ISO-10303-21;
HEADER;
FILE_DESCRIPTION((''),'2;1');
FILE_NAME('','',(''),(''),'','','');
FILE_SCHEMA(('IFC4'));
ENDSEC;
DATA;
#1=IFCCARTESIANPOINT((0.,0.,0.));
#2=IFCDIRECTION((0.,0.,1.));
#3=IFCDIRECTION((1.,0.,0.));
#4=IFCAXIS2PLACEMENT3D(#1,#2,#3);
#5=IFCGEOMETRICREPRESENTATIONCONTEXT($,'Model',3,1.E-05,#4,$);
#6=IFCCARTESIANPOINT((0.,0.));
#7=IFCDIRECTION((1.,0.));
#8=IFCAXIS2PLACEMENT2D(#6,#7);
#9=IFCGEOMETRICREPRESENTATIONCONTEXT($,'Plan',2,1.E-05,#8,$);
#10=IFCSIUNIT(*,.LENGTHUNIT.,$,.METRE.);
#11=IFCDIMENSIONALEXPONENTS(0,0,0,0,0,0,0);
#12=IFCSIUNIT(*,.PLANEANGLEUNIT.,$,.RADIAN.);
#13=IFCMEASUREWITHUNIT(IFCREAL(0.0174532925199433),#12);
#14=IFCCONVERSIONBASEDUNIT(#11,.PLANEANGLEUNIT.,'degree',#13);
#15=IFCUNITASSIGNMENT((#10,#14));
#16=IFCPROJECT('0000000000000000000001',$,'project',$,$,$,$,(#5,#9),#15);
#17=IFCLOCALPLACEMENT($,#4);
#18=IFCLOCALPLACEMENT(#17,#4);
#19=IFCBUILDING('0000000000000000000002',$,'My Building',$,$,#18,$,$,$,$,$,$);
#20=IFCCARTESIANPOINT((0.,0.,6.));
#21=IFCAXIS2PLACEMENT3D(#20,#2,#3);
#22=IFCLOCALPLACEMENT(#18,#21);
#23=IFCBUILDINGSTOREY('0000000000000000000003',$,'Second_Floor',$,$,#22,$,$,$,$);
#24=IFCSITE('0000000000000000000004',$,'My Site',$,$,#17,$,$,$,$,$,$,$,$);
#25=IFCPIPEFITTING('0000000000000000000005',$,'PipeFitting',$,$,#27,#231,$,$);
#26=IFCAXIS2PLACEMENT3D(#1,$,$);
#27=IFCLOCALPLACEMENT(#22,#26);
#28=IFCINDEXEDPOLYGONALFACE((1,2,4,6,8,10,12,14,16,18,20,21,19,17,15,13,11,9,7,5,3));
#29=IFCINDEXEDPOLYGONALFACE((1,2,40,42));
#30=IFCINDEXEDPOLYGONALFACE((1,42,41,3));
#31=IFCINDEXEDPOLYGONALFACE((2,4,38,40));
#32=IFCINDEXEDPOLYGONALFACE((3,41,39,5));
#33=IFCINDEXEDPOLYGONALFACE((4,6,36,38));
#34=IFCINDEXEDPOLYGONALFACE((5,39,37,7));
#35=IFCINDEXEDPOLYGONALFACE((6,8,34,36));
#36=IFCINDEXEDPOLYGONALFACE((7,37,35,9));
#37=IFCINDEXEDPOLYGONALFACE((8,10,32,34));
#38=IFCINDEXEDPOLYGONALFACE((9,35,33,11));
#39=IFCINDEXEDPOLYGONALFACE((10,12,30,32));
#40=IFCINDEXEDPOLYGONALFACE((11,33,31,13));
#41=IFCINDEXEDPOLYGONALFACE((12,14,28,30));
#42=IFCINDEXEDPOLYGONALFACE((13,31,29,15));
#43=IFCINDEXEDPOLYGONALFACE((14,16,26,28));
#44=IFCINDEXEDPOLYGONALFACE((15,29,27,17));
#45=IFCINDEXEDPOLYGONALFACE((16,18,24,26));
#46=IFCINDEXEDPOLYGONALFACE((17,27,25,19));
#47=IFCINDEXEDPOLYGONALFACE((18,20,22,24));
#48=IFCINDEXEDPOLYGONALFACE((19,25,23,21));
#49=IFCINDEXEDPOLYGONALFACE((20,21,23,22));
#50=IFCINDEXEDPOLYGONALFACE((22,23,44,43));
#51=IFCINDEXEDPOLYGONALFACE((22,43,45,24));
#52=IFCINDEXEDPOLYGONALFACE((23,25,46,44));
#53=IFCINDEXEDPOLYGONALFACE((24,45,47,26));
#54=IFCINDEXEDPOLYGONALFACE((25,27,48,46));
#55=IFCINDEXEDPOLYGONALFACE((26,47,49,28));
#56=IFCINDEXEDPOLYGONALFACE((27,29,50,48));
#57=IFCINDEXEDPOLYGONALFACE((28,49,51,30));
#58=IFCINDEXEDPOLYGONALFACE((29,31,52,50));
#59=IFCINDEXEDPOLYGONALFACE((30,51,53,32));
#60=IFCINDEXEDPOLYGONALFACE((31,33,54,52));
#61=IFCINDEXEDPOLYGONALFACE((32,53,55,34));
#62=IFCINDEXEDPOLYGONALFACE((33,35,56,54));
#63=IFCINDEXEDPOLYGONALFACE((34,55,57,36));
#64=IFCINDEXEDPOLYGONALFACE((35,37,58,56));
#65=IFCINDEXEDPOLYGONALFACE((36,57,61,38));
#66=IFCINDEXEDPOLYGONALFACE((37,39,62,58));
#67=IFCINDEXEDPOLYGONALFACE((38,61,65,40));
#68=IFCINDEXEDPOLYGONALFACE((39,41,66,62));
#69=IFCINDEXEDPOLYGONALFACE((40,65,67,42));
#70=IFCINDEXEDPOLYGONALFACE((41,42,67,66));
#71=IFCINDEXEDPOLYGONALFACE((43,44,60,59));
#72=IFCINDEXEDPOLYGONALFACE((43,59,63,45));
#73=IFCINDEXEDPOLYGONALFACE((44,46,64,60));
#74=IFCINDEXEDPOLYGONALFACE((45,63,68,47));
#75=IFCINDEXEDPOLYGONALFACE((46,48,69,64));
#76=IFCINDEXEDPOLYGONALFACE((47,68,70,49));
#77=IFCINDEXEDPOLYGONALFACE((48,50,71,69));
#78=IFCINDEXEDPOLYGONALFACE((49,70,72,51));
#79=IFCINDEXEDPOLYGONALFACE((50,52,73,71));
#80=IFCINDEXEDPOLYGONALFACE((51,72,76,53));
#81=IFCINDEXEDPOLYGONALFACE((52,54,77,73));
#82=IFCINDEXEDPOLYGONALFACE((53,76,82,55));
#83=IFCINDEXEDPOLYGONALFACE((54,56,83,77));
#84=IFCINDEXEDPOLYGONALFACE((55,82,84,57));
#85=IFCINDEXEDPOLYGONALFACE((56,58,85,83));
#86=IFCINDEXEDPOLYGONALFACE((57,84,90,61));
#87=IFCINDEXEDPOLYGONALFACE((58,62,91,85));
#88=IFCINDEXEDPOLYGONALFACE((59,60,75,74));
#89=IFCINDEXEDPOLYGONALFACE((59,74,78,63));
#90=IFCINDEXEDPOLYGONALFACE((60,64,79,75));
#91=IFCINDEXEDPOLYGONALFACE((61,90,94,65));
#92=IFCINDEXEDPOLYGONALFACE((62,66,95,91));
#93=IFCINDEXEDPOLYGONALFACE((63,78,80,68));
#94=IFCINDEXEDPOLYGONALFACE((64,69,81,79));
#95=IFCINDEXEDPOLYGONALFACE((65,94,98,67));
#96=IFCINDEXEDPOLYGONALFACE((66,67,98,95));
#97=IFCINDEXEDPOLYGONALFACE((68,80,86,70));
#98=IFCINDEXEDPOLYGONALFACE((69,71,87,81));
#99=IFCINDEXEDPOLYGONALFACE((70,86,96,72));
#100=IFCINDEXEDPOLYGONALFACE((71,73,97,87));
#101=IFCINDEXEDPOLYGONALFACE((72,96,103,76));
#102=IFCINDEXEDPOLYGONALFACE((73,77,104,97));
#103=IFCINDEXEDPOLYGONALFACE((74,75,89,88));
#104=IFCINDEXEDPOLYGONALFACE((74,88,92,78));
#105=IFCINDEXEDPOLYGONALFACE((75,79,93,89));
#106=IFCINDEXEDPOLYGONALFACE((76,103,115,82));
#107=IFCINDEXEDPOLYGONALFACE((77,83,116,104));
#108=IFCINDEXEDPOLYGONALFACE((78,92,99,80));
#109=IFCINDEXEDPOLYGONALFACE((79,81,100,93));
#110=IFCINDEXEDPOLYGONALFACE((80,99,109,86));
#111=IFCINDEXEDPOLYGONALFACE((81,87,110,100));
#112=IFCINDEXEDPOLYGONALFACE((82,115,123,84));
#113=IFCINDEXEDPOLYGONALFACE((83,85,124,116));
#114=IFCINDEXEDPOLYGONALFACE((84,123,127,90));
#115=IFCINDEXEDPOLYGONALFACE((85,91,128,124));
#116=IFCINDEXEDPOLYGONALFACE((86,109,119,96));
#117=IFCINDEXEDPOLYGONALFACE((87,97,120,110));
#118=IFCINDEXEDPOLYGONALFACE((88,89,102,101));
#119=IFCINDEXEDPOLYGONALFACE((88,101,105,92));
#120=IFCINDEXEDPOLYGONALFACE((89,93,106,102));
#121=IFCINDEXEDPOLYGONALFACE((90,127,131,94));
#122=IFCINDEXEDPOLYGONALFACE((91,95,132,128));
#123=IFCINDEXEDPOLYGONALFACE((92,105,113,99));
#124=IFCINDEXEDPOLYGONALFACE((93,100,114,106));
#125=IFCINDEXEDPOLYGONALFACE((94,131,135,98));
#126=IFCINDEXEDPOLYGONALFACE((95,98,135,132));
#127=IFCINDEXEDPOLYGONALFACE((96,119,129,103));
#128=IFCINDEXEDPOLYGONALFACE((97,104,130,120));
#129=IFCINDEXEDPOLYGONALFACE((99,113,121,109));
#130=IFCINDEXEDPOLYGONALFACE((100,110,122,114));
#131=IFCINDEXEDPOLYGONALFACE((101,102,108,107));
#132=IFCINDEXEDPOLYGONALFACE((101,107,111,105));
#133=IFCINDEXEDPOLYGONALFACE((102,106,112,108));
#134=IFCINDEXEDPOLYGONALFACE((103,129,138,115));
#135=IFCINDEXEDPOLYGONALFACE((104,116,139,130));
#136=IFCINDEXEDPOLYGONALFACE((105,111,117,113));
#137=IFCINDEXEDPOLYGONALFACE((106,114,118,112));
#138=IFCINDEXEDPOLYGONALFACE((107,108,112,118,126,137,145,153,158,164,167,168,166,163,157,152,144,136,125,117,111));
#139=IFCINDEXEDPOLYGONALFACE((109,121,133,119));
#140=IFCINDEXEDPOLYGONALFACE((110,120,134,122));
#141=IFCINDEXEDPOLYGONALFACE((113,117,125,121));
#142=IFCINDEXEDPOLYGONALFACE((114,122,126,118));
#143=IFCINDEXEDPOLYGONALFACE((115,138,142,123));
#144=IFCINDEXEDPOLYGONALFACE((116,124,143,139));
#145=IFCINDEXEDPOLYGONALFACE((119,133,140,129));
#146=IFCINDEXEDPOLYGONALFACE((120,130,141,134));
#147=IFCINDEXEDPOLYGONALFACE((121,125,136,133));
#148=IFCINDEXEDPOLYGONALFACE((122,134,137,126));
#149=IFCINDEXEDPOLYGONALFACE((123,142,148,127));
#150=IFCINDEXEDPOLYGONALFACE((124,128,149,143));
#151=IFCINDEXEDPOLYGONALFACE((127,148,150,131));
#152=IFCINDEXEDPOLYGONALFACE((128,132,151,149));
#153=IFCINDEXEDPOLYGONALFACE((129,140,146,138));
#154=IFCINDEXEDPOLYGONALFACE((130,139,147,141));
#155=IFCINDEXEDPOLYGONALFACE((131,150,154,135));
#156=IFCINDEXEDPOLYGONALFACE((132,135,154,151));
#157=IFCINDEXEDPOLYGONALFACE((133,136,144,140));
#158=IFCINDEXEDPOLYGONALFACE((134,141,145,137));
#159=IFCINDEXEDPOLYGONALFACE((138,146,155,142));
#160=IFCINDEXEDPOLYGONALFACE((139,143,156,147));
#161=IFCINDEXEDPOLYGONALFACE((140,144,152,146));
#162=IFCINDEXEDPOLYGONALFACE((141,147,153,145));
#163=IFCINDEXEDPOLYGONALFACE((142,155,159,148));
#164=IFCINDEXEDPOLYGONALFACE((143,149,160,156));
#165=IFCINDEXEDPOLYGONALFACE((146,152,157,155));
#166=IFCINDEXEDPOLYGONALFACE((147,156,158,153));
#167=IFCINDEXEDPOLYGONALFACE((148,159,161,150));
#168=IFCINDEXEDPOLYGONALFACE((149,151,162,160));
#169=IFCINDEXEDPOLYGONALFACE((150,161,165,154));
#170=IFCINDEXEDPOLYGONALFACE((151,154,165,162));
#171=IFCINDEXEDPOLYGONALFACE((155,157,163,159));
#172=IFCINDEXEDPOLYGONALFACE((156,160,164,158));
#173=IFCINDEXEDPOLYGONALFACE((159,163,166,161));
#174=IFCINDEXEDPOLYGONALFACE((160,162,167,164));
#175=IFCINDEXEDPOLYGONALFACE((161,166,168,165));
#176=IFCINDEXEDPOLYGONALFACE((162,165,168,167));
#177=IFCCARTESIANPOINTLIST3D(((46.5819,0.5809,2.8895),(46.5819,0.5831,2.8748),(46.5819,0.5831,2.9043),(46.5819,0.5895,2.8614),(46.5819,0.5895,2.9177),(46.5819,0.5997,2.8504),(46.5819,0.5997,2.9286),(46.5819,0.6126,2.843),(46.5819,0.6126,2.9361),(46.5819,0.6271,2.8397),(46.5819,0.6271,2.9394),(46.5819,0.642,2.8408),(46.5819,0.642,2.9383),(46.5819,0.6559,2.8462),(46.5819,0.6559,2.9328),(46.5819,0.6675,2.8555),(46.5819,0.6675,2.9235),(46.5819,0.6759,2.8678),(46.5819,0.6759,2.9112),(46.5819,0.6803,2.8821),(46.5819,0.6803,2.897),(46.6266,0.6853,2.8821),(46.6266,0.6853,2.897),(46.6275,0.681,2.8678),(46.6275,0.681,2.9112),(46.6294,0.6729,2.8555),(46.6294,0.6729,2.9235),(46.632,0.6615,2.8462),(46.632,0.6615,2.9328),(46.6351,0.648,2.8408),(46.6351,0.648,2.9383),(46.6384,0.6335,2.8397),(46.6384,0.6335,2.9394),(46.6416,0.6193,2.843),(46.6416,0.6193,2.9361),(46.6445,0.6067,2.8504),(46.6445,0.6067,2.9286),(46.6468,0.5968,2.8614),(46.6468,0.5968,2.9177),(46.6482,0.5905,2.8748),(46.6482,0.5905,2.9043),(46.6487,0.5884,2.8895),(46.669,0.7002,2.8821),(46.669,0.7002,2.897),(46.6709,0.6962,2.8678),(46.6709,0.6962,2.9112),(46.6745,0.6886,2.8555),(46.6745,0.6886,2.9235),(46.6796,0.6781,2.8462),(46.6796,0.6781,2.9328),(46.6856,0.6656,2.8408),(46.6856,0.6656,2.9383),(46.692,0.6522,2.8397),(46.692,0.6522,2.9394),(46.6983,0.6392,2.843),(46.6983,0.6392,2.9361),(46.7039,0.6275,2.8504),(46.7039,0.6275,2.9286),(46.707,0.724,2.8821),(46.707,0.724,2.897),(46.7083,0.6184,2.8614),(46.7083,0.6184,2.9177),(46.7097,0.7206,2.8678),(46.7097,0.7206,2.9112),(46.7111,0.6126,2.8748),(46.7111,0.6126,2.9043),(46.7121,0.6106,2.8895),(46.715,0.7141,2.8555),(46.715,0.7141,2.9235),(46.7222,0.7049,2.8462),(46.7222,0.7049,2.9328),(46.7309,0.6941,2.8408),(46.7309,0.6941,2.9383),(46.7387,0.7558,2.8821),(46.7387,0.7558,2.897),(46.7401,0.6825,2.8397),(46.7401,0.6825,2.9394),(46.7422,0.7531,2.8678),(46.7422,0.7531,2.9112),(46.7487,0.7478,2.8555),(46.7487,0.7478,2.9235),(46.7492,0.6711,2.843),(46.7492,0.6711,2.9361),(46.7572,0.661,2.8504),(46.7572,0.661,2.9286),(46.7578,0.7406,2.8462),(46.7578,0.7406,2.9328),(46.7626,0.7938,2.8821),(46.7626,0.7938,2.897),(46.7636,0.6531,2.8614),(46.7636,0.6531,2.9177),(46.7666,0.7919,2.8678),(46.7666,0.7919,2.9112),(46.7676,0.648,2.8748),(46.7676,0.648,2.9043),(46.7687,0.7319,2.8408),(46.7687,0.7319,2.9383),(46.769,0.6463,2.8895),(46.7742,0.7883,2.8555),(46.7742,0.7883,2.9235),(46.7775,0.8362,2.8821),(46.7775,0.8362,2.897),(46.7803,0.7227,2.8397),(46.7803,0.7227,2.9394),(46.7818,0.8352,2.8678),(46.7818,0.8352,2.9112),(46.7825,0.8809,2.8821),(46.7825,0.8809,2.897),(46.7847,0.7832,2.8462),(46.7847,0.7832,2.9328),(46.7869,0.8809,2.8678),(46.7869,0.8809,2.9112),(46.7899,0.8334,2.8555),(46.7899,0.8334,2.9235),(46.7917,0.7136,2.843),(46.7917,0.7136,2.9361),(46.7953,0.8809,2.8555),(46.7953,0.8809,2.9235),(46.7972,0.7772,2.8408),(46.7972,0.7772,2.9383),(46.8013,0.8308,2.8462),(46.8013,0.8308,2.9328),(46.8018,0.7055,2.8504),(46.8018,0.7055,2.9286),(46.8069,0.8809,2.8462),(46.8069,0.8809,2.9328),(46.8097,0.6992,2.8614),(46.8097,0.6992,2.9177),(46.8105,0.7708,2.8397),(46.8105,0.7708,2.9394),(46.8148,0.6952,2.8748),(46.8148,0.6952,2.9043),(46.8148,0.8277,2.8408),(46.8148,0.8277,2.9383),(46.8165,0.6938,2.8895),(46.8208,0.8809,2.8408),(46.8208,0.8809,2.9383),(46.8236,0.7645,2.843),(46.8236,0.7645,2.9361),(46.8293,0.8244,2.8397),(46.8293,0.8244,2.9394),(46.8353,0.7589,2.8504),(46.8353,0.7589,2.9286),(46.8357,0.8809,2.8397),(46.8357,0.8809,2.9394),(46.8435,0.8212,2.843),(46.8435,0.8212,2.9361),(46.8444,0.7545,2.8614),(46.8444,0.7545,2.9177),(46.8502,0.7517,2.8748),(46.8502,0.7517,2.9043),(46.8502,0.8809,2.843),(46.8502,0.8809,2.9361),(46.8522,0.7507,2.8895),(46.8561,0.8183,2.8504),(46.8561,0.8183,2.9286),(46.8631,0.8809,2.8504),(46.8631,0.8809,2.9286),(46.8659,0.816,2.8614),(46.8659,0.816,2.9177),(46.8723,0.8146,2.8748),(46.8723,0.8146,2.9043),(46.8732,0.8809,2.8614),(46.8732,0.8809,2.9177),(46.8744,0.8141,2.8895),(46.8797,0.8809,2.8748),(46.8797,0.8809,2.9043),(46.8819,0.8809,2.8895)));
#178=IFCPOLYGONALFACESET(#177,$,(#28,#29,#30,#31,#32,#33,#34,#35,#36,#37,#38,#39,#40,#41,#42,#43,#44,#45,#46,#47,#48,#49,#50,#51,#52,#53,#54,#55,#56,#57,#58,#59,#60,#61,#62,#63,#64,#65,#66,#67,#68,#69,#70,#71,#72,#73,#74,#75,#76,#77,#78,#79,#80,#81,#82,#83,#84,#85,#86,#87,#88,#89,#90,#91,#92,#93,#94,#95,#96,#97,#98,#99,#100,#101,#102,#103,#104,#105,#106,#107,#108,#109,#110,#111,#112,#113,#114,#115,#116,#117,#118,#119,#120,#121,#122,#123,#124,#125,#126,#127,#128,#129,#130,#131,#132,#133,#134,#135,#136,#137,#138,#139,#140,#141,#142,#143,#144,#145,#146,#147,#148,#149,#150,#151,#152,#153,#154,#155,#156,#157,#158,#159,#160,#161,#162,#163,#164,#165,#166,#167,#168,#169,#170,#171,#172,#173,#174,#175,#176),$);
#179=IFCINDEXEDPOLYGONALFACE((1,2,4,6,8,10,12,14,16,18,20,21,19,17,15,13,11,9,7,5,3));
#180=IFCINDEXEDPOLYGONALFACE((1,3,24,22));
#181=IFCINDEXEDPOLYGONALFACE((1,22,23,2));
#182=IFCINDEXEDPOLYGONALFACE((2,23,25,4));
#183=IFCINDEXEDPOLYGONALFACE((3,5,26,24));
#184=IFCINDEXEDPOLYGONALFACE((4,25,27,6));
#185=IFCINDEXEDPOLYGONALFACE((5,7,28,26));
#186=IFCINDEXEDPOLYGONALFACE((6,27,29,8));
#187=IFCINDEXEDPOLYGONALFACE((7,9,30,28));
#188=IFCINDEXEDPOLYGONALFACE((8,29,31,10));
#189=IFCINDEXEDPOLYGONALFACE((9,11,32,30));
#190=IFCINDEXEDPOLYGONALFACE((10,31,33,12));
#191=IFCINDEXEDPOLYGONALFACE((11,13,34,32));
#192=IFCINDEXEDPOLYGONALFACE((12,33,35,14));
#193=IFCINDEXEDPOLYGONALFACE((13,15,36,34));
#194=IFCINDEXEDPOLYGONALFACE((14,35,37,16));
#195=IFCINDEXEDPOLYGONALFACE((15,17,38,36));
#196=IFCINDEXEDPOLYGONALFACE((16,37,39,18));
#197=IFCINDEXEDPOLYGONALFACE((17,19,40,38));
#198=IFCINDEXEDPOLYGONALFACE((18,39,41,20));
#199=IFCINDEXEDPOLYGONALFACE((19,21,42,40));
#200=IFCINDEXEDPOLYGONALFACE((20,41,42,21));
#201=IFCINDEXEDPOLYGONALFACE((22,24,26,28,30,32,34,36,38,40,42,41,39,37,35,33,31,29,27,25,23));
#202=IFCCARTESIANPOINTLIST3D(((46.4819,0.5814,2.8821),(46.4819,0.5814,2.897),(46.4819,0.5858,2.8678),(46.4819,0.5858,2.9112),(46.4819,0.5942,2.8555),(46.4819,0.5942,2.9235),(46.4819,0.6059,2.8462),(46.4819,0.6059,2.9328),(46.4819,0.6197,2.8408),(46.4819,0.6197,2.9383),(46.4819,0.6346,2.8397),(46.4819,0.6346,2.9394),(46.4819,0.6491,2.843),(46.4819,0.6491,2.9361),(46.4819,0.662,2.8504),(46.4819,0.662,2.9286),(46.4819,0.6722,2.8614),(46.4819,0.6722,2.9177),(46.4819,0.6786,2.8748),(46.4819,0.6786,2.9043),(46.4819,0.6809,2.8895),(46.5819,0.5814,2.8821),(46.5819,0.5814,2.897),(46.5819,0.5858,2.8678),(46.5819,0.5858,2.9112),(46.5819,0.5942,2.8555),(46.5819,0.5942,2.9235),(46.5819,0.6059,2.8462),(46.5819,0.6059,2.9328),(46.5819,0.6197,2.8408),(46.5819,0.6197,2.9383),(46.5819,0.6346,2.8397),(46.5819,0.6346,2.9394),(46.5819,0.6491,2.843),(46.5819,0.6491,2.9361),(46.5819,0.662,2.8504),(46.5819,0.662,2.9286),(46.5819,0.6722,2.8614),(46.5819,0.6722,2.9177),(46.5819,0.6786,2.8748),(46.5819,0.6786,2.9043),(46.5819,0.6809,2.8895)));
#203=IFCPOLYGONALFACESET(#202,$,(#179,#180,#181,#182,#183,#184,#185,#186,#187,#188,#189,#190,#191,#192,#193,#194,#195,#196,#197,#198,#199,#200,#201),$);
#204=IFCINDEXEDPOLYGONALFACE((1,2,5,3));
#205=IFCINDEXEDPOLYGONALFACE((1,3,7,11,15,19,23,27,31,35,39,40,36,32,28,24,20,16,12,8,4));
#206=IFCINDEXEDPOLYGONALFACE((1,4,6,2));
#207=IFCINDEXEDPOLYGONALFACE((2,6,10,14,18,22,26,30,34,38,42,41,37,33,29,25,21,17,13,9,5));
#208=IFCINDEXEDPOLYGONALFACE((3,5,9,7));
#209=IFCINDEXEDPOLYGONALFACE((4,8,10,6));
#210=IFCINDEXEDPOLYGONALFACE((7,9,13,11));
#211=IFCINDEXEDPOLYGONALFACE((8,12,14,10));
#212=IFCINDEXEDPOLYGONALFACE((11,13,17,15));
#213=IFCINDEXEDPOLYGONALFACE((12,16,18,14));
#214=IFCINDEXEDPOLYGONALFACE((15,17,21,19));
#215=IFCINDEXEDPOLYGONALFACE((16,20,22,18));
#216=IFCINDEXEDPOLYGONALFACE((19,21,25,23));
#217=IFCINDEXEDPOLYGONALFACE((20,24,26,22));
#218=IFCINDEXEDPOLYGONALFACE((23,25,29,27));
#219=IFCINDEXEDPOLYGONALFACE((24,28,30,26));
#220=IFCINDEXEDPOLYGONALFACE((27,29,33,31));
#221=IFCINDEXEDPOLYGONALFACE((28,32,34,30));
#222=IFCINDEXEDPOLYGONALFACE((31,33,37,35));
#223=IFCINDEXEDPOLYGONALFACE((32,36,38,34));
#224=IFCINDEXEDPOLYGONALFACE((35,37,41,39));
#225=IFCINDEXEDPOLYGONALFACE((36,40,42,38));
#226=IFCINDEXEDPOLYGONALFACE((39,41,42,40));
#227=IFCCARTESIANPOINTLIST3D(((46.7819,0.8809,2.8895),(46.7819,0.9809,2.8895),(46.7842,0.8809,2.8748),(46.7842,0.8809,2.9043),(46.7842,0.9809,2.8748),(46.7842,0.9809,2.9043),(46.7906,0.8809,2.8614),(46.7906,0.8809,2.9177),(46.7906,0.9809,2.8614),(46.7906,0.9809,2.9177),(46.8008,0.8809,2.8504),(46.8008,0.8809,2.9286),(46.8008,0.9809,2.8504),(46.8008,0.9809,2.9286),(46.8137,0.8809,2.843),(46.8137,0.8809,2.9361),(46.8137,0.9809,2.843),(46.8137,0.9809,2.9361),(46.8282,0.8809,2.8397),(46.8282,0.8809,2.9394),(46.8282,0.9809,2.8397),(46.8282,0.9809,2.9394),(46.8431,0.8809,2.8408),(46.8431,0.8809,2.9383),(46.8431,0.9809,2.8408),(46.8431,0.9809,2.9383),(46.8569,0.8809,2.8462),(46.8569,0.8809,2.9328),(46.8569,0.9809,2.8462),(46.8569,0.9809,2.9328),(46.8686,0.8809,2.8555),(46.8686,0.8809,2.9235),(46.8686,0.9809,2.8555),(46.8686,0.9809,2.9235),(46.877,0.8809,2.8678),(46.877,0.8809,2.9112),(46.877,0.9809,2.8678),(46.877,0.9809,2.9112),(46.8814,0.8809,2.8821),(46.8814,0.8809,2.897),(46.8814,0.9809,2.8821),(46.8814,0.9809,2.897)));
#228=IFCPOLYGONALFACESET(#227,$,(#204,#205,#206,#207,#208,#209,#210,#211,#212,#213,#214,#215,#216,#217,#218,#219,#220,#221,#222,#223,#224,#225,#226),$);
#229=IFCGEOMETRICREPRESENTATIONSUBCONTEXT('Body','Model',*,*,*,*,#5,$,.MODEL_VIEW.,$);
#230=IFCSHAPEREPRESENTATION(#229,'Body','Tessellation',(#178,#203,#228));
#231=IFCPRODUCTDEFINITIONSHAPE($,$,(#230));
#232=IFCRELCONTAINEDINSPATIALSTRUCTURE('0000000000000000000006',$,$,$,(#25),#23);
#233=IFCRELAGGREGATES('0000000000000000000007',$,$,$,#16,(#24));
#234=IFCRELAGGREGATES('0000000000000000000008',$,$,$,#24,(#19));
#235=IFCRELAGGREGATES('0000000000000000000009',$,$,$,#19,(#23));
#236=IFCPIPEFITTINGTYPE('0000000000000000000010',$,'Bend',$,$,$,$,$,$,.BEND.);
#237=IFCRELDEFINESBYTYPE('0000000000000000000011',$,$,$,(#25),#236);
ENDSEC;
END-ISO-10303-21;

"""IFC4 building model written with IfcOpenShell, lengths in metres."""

from ifc_helpers import new_model, entity, si_unit, converted_unit, frame, origin_with_axes, origin_2d_with_axis, place, context, subcontext, project, spatial, circle, extrude, source, transform, mapped, type_object, type_shapes, element, save


model = new_model("IFC4")

# Units and contexts
model_context = context("Model", 3, precision=1e-05, world=origin_with_axes())
plan_context = context("Plan", 2, precision=1e-05, world=origin_2d_with_axis())
body_context = subcontext(model_context, "Body", "Model", "MODEL_VIEW")
ifc_project = project(units=[si_unit("LENGTHUNIT", "METRE"), converted_unit("PLANEANGLEUNIT", "degree", entity("IfcReal", 0.0174532925199433), si_unit("PLANEANGLEUNIT", "RADIAN"), dimensions=[0, 0, 0, 0, 0, 0, 0])], contexts=[model_context, plan_context])

# Site, building, storey
site_placement = place(None, origin_with_axes())
site = spatial("IfcSite", under=ifc_project, at=site_placement, Name="My Site")
building_placement = place(site_placement, origin_with_axes())
building = spatial("IfcBuilding", under=site, at=building_placement, Name="My Building")
storey_placement = place(building_placement, frame((0.0, 0.0, 6.0), z_axis=(0.0, 0.0, 1.0), x_axis=(1.0, 0.0, 0.0)))
storey = spatial("IfcBuildingStorey", under=building, at=storey_placement, Name="Second_Floor")

# Pipe fitting
pipe_fitting_type = type_object("IfcPipeFittingType", Name="Bend", PredefinedType="BEND")
shared_shape = source(origin_with_axes(), body_context, "Body", "SolidModel", [
    entity("IfcSweptDiskSolid", entity("IfcIndexedPolyCurve", entity("IfcCartesianPointList3D", [[0.0, 0.0, -0.1], [0.0732, 0.0, -0.2768], [0.25, 0.0, -0.35]]), [entity("IfcArcIndex", [1, 2, 3])]), 0.05),
    extrude(circle(Radius=0.05), origin_with_axes(), (0.0, 0.0, -1.0), 0.1),
    extrude(circle(Radius=0.05), frame((0.25, 0.0, -0.35), z_axis=(1.0, 0.0, 0.0), x_axis=(0.0, 0.0, 1.0)), (0.0, 0.0, 1.0), 0.1),
])
type_shapes(pipe_fitting_type, [shared_shape])
pipe_fitting_placement = place(storey_placement, frame((46.4819, 0.6309, 2.8895), z_axis=(-1.0, 0.000001, 0.0), x_axis=(0.000001, 1.0, 0.0)))
element("IfcPipeFitting", 1, at=pipe_fitting_placement, inside=storey, type_object=pipe_fitting_type, Name="PipeFitting", context=body_context, shape_type="MappedRepresentation", body=[
    mapped(shared_shape, transform((0.0, 0.0, 0.0), x_axis=(1.0, 0.0, 0.0), y_axis=(0.0, 1.0, 0.0), z_axis=(0.0, 0.0, 1.0), scale=1.0)),
])

save(model, "model.ifc")
